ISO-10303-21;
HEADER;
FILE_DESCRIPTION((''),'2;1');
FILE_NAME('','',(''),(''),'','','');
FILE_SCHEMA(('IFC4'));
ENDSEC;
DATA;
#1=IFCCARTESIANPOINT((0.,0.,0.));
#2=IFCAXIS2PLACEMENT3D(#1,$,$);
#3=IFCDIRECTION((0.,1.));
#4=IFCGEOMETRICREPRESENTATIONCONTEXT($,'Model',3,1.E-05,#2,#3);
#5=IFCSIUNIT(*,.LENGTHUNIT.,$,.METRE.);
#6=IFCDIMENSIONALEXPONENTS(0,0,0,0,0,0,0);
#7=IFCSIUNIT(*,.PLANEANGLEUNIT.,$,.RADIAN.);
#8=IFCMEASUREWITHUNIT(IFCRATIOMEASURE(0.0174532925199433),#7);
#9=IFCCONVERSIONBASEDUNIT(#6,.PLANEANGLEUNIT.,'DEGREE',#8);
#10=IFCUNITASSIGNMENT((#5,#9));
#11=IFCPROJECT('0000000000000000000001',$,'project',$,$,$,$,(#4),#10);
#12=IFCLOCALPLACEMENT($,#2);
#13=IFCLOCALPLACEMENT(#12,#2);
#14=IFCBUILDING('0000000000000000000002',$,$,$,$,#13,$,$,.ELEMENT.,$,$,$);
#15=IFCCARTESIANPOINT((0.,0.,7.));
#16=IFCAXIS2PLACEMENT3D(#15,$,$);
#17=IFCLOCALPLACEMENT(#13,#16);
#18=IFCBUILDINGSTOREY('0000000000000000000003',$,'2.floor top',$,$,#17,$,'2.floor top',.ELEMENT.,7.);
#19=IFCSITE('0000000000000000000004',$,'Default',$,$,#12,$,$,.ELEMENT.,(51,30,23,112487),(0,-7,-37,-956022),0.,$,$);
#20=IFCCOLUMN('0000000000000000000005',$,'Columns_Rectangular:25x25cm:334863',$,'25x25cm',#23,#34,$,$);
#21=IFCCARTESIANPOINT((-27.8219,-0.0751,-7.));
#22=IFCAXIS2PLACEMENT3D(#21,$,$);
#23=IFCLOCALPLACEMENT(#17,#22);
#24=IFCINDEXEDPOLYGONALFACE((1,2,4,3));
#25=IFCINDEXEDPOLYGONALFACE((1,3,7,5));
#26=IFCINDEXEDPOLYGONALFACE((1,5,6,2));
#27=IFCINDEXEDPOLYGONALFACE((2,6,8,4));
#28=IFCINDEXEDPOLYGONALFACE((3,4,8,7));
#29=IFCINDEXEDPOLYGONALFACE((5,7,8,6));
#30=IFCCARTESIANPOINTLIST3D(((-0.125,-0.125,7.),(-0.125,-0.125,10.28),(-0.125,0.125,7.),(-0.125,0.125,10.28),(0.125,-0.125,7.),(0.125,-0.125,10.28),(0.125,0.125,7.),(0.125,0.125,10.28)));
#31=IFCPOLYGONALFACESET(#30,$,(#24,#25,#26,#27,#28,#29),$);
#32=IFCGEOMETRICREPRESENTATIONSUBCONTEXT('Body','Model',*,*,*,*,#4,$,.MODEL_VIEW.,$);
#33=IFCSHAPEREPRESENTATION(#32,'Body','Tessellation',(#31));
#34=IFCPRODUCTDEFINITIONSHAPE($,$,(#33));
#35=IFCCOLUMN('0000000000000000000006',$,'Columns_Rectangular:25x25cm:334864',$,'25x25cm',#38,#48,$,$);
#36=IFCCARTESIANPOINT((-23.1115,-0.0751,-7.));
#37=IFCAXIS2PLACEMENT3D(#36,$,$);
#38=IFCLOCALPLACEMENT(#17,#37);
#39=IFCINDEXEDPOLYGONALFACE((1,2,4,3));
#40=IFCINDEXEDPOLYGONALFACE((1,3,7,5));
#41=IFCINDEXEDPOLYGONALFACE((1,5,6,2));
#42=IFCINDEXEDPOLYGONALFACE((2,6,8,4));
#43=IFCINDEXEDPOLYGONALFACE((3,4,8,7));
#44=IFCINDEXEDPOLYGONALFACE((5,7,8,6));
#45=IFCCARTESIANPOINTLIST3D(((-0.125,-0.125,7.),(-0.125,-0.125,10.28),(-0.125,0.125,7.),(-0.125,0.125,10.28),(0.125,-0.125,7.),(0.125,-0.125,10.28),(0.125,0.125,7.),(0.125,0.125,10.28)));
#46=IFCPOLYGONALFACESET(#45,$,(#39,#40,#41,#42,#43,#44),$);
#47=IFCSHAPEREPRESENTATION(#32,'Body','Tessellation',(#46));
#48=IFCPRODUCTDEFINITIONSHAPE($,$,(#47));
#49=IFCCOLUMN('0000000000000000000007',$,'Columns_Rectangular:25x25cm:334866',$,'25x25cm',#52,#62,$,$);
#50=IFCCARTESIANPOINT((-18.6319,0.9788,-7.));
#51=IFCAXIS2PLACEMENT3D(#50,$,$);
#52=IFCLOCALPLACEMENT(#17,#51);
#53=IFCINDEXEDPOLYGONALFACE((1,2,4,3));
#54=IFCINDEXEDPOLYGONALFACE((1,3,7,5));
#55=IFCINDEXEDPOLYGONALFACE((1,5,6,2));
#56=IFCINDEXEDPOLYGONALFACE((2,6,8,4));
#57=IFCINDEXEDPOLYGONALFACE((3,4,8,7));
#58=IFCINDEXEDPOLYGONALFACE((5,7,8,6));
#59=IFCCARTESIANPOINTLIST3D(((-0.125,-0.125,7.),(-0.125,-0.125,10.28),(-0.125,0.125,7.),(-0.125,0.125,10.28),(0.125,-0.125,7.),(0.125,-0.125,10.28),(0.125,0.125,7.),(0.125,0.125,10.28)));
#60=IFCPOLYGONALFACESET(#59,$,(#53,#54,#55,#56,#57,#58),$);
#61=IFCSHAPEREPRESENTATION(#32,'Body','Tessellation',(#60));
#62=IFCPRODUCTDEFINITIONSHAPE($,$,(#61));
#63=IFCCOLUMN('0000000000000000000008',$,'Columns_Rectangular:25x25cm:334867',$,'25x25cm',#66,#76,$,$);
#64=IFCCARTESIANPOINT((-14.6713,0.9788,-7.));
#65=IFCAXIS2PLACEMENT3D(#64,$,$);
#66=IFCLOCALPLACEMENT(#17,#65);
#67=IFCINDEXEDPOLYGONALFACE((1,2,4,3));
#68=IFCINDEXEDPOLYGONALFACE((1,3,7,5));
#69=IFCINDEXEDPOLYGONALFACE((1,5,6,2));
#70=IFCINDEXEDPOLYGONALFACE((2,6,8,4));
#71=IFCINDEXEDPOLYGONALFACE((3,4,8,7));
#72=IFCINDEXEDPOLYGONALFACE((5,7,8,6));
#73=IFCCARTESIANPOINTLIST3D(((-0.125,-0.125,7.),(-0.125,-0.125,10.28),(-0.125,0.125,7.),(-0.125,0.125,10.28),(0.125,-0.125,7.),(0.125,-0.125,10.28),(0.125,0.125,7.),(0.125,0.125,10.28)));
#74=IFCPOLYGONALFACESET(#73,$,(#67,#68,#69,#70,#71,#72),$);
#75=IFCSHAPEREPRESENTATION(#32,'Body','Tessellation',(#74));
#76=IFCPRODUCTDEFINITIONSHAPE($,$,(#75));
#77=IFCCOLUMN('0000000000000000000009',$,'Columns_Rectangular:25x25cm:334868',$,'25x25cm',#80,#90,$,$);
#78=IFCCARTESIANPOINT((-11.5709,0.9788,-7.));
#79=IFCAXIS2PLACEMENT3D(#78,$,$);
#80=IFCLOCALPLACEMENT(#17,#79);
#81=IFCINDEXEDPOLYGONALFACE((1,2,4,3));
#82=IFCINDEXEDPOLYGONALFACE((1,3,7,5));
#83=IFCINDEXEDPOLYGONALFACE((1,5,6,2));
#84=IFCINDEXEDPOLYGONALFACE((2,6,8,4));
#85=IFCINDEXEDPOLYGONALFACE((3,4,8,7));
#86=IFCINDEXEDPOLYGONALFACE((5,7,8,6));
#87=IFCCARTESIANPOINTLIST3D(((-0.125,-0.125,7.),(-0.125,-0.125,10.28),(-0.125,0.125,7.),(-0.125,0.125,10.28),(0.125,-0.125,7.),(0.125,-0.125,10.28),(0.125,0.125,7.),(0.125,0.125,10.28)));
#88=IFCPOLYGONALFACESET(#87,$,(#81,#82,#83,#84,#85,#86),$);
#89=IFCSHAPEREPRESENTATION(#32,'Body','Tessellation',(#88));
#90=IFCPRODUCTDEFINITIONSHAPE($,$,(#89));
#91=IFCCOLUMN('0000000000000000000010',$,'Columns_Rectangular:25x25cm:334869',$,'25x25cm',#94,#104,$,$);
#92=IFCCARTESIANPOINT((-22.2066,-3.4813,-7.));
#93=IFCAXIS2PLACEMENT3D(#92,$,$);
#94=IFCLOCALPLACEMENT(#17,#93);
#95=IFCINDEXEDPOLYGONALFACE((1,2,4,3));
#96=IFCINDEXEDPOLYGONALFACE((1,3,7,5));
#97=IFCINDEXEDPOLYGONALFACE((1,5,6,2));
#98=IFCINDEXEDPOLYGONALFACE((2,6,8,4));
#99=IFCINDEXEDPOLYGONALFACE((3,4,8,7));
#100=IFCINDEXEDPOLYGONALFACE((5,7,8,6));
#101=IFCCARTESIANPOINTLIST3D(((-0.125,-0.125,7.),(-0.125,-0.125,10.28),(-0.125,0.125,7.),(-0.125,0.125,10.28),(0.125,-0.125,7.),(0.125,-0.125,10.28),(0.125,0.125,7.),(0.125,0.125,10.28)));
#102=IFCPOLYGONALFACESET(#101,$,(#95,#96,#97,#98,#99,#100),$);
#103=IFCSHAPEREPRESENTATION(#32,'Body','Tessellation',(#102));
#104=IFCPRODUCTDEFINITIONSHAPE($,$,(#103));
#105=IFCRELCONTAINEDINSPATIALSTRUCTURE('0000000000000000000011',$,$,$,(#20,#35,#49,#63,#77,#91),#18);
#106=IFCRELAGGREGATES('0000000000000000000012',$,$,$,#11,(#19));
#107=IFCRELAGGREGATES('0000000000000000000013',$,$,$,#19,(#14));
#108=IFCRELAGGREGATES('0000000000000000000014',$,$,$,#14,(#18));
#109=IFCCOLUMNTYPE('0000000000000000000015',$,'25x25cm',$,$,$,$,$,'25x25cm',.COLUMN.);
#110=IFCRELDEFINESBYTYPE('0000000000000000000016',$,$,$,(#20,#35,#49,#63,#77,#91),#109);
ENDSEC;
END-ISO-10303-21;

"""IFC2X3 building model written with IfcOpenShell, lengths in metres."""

from ifc_helpers import new_model, entity, si_unit, converted_unit, direction, frame, origin, origin_2d_with_axis, place, context, subcontext, project, spatial, rectangle, extrude, source, transform, mapped, type_object, type_shapes, element, save


model = new_model("IFC2X3")

# Units and contexts
model_context = context("Model", 3, precision=1e-05, world=origin(), true_north=direction((0.0, 1.0)))
body_context = subcontext(model_context, "Body", "Model", "MODEL_VIEW")
ifc_project = project(units=[si_unit("LENGTHUNIT", "METRE"), converted_unit("PLANEANGLEUNIT", "DEGREE", entity("IfcRatioMeasure", 0.0174532925199433), si_unit("PLANEANGLEUNIT", "RADIAN"), dimensions=[0, 0, 0, 0, 0, 0, 0])], contexts=[model_context])

# Site, building, storey
site_placement = place(None, origin())
site = spatial("IfcSite", under=ifc_project, at=site_placement, Name="Default", CompositionType="ELEMENT", RefLatitude=(51, 30, 23, 112487), RefLongitude=(0, -7, -37, -956022), RefElevation=0.0)
building_placement = place(site_placement, origin())
building = spatial("IfcBuilding", under=site, at=building_placement, CompositionType="ELEMENT")
storey_placement = place(building_placement, frame((0.0, 0.0, 7.0)))
storey = spatial("IfcBuildingStorey", under=building, at=storey_placement, Name="2.floor top", LongName="2.floor top", CompositionType="ELEMENT", Elevation=7.0)

# Columns
column_type = type_object("IfcColumnType", Name="25x25cm", ElementType="25x25cm", PredefinedType="COLUMN")
shared_shape = source(origin(), body_context, "Body", "SweptSolid", [
    extrude(rectangle(XDim=0.25, YDim=0.25, at=origin_2d_with_axis()), frame((0.0, 0.0, 7.0), z_axis=(0.0, 0.0, 1.0), x_axis=(0.0, -1.0, 0.0)), (0.0, 0.0, 1.0), 3.28),
])
type_shapes(column_type, [shared_shape])
for number, where, name in (
    (1, (-27.8219, -0.0751, -7.0), "Columns_Rectangular:25x25cm:334863"),
    (2, (-23.1115, -0.0751, -7.0), "Columns_Rectangular:25x25cm:334864"),
    (3, (-18.6319, 0.9788, -7.0), "Columns_Rectangular:25x25cm:334866"),
    (4, (-14.6713, 0.9788, -7.0), "Columns_Rectangular:25x25cm:334867"),
    (5, (-11.5709, 0.9788, -7.0), "Columns_Rectangular:25x25cm:334868"),
    (6, (-22.2066, -3.4813, -7.0), "Columns_Rectangular:25x25cm:334869"),
):
    element("IfcColumn", number, at=place(storey_placement, frame(where)), inside=storey, type_object=column_type, Name=name, ObjectType="25x25cm", context=body_context, shape_type="MappedRepresentation", body=[
        mapped(shared_shape, transform((0.0, 0.0, 0.0), scale=1.0)),
    ])

save(model, "model.ifc")
